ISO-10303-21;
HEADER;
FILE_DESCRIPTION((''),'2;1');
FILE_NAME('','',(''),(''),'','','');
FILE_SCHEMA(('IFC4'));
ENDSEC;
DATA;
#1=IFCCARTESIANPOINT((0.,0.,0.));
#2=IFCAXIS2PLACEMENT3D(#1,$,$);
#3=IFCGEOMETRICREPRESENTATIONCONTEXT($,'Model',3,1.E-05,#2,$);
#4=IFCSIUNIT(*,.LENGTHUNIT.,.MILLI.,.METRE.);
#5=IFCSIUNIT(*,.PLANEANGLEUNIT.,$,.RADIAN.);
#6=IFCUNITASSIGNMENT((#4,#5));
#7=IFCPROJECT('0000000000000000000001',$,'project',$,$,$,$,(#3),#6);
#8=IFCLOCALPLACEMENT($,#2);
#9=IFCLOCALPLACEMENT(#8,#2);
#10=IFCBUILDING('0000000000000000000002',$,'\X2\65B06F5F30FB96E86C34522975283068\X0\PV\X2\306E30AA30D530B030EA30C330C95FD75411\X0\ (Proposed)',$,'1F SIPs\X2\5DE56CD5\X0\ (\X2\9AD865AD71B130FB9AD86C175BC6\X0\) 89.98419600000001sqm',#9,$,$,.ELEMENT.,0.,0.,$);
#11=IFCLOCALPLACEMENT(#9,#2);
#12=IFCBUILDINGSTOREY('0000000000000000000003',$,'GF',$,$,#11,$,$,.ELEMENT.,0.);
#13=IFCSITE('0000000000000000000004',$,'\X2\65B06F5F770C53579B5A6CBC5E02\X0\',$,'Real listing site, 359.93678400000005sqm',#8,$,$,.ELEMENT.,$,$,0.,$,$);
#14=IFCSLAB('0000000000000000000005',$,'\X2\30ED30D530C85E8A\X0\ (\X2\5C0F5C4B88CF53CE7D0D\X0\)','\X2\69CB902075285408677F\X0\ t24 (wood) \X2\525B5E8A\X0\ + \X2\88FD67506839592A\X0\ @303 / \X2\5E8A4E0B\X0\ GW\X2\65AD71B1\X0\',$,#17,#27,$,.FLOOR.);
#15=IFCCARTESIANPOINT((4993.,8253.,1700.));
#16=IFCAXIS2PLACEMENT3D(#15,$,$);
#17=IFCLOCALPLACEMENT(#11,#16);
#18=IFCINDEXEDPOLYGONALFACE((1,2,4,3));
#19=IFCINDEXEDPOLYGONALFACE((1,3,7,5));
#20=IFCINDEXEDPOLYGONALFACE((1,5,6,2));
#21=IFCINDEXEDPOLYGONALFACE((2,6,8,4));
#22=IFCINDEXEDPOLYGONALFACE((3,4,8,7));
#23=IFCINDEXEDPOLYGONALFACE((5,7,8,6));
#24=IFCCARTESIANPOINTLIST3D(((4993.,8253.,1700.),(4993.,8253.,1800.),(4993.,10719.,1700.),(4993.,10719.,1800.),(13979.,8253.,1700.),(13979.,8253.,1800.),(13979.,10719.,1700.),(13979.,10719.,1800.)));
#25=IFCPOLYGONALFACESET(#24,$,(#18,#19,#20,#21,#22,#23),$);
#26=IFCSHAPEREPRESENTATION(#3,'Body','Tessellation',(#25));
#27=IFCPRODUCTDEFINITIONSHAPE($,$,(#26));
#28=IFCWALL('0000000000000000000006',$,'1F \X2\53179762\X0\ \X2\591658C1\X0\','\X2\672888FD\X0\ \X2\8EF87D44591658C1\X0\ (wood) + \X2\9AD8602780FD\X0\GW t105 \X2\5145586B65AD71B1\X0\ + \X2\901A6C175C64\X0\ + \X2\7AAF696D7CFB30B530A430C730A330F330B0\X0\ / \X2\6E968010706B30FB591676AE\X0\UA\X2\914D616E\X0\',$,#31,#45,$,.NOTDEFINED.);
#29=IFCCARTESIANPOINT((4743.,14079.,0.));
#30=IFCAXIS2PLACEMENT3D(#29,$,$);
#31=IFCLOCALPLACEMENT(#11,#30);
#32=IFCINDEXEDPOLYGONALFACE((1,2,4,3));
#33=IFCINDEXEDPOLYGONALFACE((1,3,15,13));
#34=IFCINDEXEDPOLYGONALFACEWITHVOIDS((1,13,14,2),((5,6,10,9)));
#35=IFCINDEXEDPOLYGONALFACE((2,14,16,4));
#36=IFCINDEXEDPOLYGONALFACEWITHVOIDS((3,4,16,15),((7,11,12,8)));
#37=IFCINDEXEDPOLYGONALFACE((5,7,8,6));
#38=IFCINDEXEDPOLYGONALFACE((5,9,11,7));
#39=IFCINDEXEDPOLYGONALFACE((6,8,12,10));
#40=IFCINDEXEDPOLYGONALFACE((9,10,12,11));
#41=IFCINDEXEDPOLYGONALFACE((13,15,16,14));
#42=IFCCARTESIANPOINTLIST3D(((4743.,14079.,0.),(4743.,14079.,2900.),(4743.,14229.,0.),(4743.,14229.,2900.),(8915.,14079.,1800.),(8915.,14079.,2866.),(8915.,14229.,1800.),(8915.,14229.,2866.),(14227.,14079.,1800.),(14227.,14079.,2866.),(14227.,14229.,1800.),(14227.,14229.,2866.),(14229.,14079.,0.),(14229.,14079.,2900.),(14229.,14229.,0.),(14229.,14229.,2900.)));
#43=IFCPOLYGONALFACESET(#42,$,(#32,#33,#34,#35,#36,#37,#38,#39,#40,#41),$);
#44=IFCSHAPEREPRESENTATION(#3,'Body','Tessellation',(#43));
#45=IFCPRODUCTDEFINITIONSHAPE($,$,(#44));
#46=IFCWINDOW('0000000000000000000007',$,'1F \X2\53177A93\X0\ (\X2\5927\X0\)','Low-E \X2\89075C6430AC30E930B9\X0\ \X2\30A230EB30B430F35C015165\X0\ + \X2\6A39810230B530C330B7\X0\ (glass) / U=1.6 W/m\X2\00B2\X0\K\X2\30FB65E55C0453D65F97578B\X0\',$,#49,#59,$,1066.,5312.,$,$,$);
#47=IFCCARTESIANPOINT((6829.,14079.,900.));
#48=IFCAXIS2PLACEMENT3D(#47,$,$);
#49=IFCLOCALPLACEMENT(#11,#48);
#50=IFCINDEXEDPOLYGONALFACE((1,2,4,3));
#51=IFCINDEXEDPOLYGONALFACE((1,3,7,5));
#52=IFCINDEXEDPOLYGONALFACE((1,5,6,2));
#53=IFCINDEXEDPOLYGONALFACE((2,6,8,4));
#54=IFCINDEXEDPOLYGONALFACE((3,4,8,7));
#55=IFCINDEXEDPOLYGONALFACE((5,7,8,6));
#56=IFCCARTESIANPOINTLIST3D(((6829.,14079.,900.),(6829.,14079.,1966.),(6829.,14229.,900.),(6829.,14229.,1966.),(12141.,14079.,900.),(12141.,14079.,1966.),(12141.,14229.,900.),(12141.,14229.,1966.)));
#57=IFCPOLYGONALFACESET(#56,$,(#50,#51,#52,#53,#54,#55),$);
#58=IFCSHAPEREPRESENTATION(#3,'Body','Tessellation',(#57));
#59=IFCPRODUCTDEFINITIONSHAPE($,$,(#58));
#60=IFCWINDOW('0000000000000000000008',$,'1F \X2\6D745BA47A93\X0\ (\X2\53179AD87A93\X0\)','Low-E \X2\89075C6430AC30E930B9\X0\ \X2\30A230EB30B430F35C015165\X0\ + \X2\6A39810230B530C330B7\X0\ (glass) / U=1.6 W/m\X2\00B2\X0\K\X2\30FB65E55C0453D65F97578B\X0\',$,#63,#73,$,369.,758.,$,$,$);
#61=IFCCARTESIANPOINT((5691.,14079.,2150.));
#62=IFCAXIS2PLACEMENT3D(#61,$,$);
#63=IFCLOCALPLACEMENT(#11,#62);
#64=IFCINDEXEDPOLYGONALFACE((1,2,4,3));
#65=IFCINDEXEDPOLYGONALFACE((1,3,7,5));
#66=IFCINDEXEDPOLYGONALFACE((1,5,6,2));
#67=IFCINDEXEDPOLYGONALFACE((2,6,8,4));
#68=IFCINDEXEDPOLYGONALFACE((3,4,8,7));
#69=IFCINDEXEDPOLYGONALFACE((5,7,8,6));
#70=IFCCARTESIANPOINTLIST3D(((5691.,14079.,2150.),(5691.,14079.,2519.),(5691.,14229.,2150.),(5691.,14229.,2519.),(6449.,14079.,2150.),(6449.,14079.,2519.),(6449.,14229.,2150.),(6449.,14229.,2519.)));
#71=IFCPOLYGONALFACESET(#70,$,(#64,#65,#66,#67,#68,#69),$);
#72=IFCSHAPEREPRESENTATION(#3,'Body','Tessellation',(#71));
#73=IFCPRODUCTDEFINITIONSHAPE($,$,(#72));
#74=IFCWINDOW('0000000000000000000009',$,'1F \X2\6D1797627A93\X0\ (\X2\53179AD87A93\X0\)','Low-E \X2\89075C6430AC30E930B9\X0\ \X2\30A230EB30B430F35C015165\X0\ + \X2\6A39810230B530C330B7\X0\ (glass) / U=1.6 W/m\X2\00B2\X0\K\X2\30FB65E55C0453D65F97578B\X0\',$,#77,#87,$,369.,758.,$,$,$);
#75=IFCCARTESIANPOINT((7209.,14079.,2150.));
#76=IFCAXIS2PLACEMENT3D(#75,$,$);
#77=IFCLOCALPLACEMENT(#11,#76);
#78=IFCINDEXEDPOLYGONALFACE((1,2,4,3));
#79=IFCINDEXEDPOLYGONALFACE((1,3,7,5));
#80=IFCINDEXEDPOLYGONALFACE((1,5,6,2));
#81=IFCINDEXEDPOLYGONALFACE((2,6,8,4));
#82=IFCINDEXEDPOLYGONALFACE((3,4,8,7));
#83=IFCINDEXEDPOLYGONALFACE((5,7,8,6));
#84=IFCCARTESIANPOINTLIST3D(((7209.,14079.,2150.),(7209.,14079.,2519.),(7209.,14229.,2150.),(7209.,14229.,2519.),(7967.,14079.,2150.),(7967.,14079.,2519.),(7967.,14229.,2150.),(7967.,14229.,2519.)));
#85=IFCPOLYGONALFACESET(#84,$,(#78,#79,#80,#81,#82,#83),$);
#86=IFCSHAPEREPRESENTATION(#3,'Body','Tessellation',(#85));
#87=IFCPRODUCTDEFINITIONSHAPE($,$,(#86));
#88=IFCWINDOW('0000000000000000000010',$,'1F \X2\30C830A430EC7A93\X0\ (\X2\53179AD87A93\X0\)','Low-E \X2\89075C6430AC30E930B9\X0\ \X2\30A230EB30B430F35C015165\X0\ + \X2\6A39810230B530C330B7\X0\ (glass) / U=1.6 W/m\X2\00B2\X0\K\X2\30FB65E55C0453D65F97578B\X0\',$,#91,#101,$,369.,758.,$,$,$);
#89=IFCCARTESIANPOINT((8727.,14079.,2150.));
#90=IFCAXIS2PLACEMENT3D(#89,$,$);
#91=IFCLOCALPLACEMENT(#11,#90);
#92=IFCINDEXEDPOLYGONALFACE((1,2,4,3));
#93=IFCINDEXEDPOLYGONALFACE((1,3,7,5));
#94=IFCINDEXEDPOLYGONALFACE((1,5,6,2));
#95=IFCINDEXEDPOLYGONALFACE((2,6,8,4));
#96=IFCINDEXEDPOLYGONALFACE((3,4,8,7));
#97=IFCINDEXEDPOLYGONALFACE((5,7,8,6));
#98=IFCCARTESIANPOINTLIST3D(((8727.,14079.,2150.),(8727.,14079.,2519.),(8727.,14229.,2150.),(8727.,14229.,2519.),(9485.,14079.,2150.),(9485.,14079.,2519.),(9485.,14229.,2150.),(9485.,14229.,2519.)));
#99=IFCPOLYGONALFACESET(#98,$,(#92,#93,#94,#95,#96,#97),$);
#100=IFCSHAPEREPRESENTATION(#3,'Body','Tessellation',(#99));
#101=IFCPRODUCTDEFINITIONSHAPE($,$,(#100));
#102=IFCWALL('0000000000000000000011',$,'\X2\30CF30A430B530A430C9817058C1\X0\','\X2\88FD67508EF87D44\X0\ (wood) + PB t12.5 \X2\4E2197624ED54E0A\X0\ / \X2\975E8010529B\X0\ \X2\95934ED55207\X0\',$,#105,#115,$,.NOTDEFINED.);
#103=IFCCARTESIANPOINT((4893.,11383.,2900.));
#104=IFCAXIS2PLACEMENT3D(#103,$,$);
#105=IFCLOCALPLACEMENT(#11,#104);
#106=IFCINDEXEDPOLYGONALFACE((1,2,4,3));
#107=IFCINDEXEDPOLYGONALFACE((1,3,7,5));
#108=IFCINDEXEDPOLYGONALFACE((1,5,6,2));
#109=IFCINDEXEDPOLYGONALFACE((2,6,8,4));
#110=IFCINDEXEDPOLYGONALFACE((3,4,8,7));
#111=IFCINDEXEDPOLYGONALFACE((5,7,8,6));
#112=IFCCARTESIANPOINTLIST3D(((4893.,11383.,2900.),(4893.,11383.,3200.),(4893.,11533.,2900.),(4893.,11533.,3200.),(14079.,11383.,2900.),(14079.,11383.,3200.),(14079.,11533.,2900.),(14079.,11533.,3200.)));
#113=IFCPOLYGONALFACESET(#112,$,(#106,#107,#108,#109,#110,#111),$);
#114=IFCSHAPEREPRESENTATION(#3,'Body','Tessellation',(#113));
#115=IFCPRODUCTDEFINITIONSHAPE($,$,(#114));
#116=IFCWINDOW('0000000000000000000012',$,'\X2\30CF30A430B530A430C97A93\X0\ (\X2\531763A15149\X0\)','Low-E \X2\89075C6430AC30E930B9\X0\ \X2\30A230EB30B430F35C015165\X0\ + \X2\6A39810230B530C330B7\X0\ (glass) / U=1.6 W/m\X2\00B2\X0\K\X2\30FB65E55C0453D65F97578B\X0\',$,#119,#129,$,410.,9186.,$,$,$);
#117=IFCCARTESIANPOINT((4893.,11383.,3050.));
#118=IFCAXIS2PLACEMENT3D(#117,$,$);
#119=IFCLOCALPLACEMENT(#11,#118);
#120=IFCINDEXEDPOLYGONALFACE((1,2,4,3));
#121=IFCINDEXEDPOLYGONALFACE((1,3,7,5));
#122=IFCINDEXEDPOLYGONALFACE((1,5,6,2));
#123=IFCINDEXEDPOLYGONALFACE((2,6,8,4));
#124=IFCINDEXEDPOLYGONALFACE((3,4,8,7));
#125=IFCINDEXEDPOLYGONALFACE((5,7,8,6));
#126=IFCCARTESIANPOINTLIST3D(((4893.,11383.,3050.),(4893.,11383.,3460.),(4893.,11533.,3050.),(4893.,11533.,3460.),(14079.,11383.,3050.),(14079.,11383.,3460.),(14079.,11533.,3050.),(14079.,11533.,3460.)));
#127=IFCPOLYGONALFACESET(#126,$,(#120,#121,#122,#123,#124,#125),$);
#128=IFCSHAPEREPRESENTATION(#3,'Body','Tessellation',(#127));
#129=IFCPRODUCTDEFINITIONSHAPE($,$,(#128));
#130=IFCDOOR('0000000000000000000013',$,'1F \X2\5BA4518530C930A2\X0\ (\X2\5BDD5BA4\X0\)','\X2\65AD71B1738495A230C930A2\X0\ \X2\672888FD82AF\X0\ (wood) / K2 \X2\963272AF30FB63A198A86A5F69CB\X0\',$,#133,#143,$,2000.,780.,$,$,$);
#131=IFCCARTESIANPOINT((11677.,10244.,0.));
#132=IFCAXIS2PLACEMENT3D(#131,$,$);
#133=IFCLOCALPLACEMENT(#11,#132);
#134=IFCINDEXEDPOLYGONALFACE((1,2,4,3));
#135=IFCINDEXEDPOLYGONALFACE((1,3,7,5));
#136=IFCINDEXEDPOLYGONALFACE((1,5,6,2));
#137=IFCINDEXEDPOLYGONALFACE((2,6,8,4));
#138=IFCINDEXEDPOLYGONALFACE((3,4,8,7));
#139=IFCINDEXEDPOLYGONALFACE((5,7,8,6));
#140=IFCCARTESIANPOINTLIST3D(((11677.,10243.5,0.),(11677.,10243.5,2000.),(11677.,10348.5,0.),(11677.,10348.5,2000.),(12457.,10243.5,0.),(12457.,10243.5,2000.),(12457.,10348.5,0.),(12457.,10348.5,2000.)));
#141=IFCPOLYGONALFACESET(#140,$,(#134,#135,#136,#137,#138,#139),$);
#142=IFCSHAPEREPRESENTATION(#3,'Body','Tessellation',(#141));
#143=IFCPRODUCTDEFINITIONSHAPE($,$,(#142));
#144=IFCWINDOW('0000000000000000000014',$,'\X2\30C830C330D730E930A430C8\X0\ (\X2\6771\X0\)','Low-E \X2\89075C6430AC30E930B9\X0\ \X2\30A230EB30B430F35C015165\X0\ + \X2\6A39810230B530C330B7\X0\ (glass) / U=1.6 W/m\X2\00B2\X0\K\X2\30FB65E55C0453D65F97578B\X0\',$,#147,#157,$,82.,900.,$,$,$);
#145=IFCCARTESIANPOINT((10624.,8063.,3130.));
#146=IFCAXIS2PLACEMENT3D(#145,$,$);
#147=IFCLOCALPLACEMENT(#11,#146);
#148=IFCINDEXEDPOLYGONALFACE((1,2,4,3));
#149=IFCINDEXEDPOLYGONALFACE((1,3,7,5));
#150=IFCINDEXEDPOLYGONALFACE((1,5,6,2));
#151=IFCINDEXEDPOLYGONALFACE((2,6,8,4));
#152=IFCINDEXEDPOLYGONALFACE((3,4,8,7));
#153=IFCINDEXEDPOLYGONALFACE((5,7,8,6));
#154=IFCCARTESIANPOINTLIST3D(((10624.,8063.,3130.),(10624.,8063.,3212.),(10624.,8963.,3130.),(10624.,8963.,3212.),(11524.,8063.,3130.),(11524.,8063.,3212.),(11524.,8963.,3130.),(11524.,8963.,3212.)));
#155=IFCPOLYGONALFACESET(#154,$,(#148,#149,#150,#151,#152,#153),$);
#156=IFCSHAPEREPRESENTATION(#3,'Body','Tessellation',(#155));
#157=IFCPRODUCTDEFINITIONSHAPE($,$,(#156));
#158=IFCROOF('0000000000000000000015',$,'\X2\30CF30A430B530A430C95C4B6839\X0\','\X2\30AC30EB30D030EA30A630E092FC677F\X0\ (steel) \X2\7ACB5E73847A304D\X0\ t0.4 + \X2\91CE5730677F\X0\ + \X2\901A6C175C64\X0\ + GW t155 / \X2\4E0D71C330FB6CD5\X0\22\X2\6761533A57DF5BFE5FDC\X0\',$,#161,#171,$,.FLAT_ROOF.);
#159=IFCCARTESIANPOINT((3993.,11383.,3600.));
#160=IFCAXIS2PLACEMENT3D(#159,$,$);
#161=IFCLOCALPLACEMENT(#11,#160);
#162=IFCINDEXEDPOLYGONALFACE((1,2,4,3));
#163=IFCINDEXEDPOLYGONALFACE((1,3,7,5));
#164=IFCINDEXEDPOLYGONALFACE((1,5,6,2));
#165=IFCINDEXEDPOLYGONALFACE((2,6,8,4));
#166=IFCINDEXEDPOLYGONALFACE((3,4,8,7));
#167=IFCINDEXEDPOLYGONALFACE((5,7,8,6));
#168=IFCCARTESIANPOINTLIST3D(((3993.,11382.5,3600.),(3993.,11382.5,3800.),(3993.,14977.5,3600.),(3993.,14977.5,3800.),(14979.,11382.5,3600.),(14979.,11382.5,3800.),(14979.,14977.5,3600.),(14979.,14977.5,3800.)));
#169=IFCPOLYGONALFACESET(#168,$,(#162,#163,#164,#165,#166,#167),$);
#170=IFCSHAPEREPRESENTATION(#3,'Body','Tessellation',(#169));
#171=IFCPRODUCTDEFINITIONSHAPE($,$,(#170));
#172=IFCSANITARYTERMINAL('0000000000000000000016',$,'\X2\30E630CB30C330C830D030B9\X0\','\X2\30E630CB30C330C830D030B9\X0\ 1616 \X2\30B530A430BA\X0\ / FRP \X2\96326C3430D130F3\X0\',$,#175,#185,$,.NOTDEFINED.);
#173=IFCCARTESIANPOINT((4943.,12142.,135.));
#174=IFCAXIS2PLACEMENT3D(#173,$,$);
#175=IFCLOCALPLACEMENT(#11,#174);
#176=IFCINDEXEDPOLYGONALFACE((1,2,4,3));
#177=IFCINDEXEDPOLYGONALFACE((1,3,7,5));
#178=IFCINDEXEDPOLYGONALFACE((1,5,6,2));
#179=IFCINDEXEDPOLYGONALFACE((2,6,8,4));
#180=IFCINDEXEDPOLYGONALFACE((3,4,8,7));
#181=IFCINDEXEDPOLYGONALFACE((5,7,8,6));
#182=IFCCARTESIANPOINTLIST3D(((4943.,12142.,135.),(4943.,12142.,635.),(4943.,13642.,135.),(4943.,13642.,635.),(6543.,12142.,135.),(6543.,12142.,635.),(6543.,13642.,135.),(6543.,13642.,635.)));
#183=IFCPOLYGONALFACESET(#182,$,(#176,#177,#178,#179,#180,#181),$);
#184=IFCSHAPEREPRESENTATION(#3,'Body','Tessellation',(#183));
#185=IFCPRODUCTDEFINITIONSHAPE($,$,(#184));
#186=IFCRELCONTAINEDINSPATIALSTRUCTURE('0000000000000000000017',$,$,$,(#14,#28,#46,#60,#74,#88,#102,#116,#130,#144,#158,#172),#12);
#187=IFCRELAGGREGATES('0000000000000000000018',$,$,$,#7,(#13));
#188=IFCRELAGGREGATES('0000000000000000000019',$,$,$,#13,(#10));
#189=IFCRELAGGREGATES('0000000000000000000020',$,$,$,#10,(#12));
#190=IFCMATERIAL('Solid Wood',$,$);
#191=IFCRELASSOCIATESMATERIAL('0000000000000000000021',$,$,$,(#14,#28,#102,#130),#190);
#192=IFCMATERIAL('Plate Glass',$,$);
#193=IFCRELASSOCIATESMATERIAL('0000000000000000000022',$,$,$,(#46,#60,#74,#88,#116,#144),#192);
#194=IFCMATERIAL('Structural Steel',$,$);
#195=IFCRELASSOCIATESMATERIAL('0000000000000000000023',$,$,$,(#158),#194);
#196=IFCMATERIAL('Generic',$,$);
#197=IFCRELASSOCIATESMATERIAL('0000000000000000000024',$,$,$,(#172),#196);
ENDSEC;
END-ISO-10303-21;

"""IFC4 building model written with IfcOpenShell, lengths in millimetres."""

from ifc_helpers import new_model, si_unit, frame, frame_2d, origin, place, context, project, spatial, rectangle, extrude, material, element, fill, save


model = new_model("IFC4")

# Units and contexts
model_context = context("Model", 3, precision=1e-05, world=origin())
ifc_project = project(units=[si_unit("LENGTHUNIT", "METRE", prefix="MILLI"), si_unit("PLANEANGLEUNIT", "RADIAN")], contexts=[model_context])

# Site, building, storey
site_placement = place(None, origin())
site = spatial("IfcSite", under=ifc_project, at=site_placement, Name="新潟県南魚沼市", ObjectType="Real listing site, 359.93678400000005sqm", CompositionType="ELEMENT", RefElevation=0.0)
building_placement = place(site_placement, origin())
building = spatial("IfcBuilding", under=site, at=building_placement, Name="新潟・雨水利用とPVのオフグリッド志向 (Proposed)", ObjectType="1F SIPs工法 (高断熱・高気密) 89.98419600000001sqm", CompositionType="ELEMENT", ElevationOfRefHeight=0.0, ElevationOfTerrain=0.0)
storey_placement = place(building_placement, origin())
storey = spatial("IfcBuildingStorey", under=building, at=storey_placement, Name="GF", CompositionType="ELEMENT", Elevation=0.0)

# Slab
ifc_material_1 = material(Name="Solid Wood")
slab_placement = place(storey_placement, frame((4993.0, 8253.0, 1700.0)))
element("IfcSlab", 1, at=slab_placement, inside=storey, material=ifc_material_1, Name="ロフト床 (小屋裏収納)", Description="構造用合板 t24 (wood) 剛床 + 製材根太 @303 / 床下 GW断熱", PredefinedType="FLOOR", context=model_context, shape_type="SweptSolid", body=[
    extrude(rectangle(XDim=8986.0, YDim=2466.0, at=frame_2d((4493.0, 1233.0))), frame((4993.0, 8253.0, 1700.0)), (0.0, 0.0, 1.0), 100.0),
])

# Wall, openings, windows
wall_1_placement = place(storey_placement, frame((4743.0, 14079.0, 0.0)))
wall_1 = element("IfcWall", 2, at=wall_1_placement, inside=storey, material=ifc_material_1, Name="1F 北面 外壁", Description="木製 軸組外壁 (wood) + 高性能GW t105 充填断熱 + 通気層 + 窯業系サイディング / 準耐火・外皮UA配慮", PredefinedType="NOTDEFINED", context=model_context, shape_type="SweptSolid", body=[
    extrude(rectangle(XDim=9486.0, YDim=150.0, at=frame_2d((4743.0, 75.0))), frame((4743.0, 14079.0, 0.0)), (0.0, 0.0, 1.0), 2900.0),
])
opening_1_placement = place(storey_placement, frame((6829.0, 14079.0, 900.0)))
opening_1 = element("IfcOpeningElement", 3, at=opening_1_placement, cuts=wall_1, PredefinedType="NOTDEFINED", context=model_context, shape_type="SweptSolid", body=[
    extrude(rectangle(XDim=5312.0, YDim=150.0, at=frame_2d((2656.0, 75.0))), frame((6829.0, 14079.0, 900.0)), (0.0, 0.0, 1.0), 1066.0),
])
opening_2_placement = place(storey_placement, frame((5691.0, 14079.0, 2150.0)))
opening_2 = element("IfcOpeningElement", 4, at=opening_2_placement, cuts=wall_1, PredefinedType="NOTDEFINED", context=model_context, shape_type="SweptSolid", body=[
    extrude(rectangle(XDim=758.0, YDim=150.0, at=frame_2d((379.0, 75.0))), frame((5691.0, 14079.0, 2150.0)), (0.0, 0.0, 1.0), 369.0),
])
opening_3_placement = place(storey_placement, frame((7209.0, 14079.0, 2150.0)))
opening_3 = element("IfcOpeningElement", 5, at=opening_3_placement, cuts=wall_1, PredefinedType="NOTDEFINED", context=model_context, shape_type="SweptSolid", body=[
    extrude(rectangle(XDim=758.0, YDim=150.0, at=frame_2d((379.0, 75.0))), frame((7209.0, 14079.0, 2150.0)), (0.0, 0.0, 1.0), 369.0),
])
opening_4_placement = place(storey_placement, frame((8727.0, 14079.0, 2150.0)))
opening_4 = element("IfcOpeningElement", 6, at=opening_4_placement, cuts=wall_1, PredefinedType="NOTDEFINED", context=model_context, shape_type="SweptSolid", body=[
    extrude(rectangle(XDim=758.0, YDim=150.0, at=frame_2d((379.0, 75.0))), frame((8727.0, 14079.0, 2150.0)), (0.0, 0.0, 1.0), 369.0),
])
ifc_material_2 = material(Name="Plate Glass")
window_1_placement = place(storey_placement, frame((6829.0, 14079.0, 900.0)))
window_1 = element("IfcWindow", 7, at=window_1_placement, inside=storey, material=ifc_material_2, Name="1F 北窓 (大)", Description="Low-E 複層ガラス アルゴン封入 + 樹脂サッシ (glass) / U=1.6 W/m²K・日射取得型", OverallHeight=1066.0, OverallWidth=5312.0, context=model_context, shape_type="SweptSolid", body=[
    extrude(rectangle(XDim=5312.0, YDim=150.0, at=frame_2d((2656.0, 75.0))), frame((6829.0, 14079.0, 900.0)), (0.0, 0.0, 1.0), 1066.0),
])
fill(opening_1, window_1)
window_2_placement = place(storey_placement, frame((5691.0, 14079.0, 2150.0)))
window_2 = element("IfcWindow", 8, at=window_2_placement, inside=storey, material=ifc_material_2, Name="1F 浴室窓 (北高窓)", Description="Low-E 複層ガラス アルゴン封入 + 樹脂サッシ (glass) / U=1.6 W/m²K・日射取得型", OverallHeight=369.0, OverallWidth=758.0, context=model_context, shape_type="SweptSolid", body=[
    extrude(rectangle(XDim=758.0, YDim=150.0, at=frame_2d((379.0, 75.0))), frame((5691.0, 14079.0, 2150.0)), (0.0, 0.0, 1.0), 369.0),
])
fill(opening_2, window_2)
window_3_placement = place(storey_placement, frame((7209.0, 14079.0, 2150.0)))
window_3 = element("IfcWindow", 9, at=window_3_placement, inside=storey, material=ifc_material_2, Name="1F 洗面窓 (北高窓)", Description="Low-E 複層ガラス アルゴン封入 + 樹脂サッシ (glass) / U=1.6 W/m²K・日射取得型", OverallHeight=369.0, OverallWidth=758.0, context=model_context, shape_type="SweptSolid", body=[
    extrude(rectangle(XDim=758.0, YDim=150.0, at=frame_2d((379.0, 75.0))), frame((7209.0, 14079.0, 2150.0)), (0.0, 0.0, 1.0), 369.0),
])
fill(opening_3, window_3)
window_4_placement = place(storey_placement, frame((8727.0, 14079.0, 2150.0)))
window_4 = element("IfcWindow", 10, at=window_4_placement, inside=storey, material=ifc_material_2, Name="1F トイレ窓 (北高窓)", Description="Low-E 複層ガラス アルゴン封入 + 樹脂サッシ (glass) / U=1.6 W/m²K・日射取得型", OverallHeight=369.0, OverallWidth=758.0, context=model_context, shape_type="SweptSolid", body=[
    extrude(rectangle(XDim=758.0, YDim=150.0, at=frame_2d((379.0, 75.0))), frame((8727.0, 14079.0, 2150.0)), (0.0, 0.0, 1.0), 369.0),
])
fill(opening_4, window_4)

# Wall, opening, window
wall_2_placement = place(storey_placement, frame((4893.0, 11383.0, 2900.0)))
wall_2 = element("IfcWall", 11, at=wall_2_placement, inside=storey, material=ifc_material_1, Name="ハイサイド腰壁", Description="製材軸組 (wood) + PB t12.5 両面仕上 / 非耐力 間仕切", PredefinedType="NOTDEFINED", context=model_context, shape_type="SweptSolid", body=[
    extrude(rectangle(XDim=9186.0, YDim=150.0, at=frame_2d((4593.0, 75.0))), frame((4893.0, 11383.0, 2900.0)), (0.0, 0.0, 1.0), 700.0),
])
opening_5_placement = place(storey_placement, frame((4893.0, 11383.0, 3050.0)))
opening_5 = element("IfcOpeningElement", 12, at=opening_5_placement, cuts=wall_2, PredefinedType="NOTDEFINED", context=model_context, shape_type="SweptSolid", body=[
    extrude(rectangle(XDim=9186.0, YDim=150.0, at=frame_2d((4593.0, 75.0))), frame((4893.0, 11383.0, 3050.0)), (0.0, 0.0, 1.0), 410.0),
])
window_5_placement = place(storey_placement, frame((4893.0, 11383.0, 3050.0)))
window_5 = element("IfcWindow", 13, at=window_5_placement, inside=storey, material=ifc_material_2, Name="ハイサイド窓 (北採光)", Description="Low-E 複層ガラス アルゴン封入 + 樹脂サッシ (glass) / U=1.6 W/m²K・日射取得型", OverallHeight=410.0, OverallWidth=9186.0, context=model_context, shape_type="SweptSolid", body=[
    extrude(rectangle(XDim=9186.0, YDim=150.0, at=frame_2d((4593.0, 75.0))), frame((4893.0, 11383.0, 3050.0)), (0.0, 0.0, 1.0), 410.0),
])
fill(opening_5, window_5)

# Door
door_1_placement = place(storey_placement, frame((11677.0, 10244.0, 0.0)))
element("IfcDoor", 14, at=door_1_placement, inside=storey, material=ifc_material_1, Name="1F 室内ドア (寝室)", Description="断熱玄関ドア 木製芯 (wood) / K2 防犯・採風機構", OverallHeight=2000.0, OverallWidth=780.0, context=model_context, shape_type="SweptSolid", body=[
    extrude(rectangle(XDim=780.0, YDim=105.0, at=frame_2d((390.0, 52.0))), frame((11677.0, 10244.0, 0.0)), (0.0, 0.0, 1.0), 2000.0),
])

# Window
window_6_placement = place(storey_placement, frame((10624.0, 8063.0, 3130.0)))
element("IfcWindow", 15, at=window_6_placement, inside=storey, material=ifc_material_2, Name="トップライト (東)", Description="Low-E 複層ガラス アルゴン封入 + 樹脂サッシ (glass) / U=1.6 W/m²K・日射取得型", OverallHeight=82.0, OverallWidth=900.0, context=model_context, shape_type="SweptSolid", body=[
    extrude(rectangle(XDim=900.0, YDim=900.0, at=frame_2d((450.0, 450.0))), frame((10624.0, 8063.0, 3130.0)), (0.0, 0.0, 1.0), 82.0),
])

# Roof
ifc_material_3 = material(Name="Structural Steel")
roof_placement = place(storey_placement, frame((3993.0, 11383.0, 3600.0)))
element("IfcRoof", 16, at=roof_placement, inside=storey, material=ifc_material_3, Name="ハイサイド屋根", Description="ガルバリウム鋼板 (steel) 立平葺き t0.4 + 野地板 + 通気層 + GW t155 / 不燃・法22条区域対応", PredefinedType="FLAT_ROOF", context=model_context, shape_type="SweptSolid", body=[
    extrude(rectangle(XDim=10986.0, YDim=3595.0, at=frame_2d((5493.0, 1797.0))), frame((3993.0, 11383.0, 3600.0)), (0.0, 0.0, 1.0), 200.0),
])

# Sanitary terminal
ifc_material_4 = material(Name="Generic")
sanitary_terminal_1_placement = place(storey_placement, frame((4943.0, 12142.0, 135.0)))
element("IfcSanitaryTerminal", 17, at=sanitary_terminal_1_placement, inside=storey, material=ifc_material_4, Name="ユニットバス", Description="ユニットバス 1616 サイズ / FRP 防水パン", PredefinedType="NOTDEFINED", context=model_context, shape_type="SweptSolid", body=[
    extrude(rectangle(XDim=1600.0, YDim=1500.0, at=frame_2d((800.0, 750.0))), frame((4943.0, 12142.0, 135.0)), (0.0, 0.0, 1.0), 500.0),
])

save(model, "model.ifc")
